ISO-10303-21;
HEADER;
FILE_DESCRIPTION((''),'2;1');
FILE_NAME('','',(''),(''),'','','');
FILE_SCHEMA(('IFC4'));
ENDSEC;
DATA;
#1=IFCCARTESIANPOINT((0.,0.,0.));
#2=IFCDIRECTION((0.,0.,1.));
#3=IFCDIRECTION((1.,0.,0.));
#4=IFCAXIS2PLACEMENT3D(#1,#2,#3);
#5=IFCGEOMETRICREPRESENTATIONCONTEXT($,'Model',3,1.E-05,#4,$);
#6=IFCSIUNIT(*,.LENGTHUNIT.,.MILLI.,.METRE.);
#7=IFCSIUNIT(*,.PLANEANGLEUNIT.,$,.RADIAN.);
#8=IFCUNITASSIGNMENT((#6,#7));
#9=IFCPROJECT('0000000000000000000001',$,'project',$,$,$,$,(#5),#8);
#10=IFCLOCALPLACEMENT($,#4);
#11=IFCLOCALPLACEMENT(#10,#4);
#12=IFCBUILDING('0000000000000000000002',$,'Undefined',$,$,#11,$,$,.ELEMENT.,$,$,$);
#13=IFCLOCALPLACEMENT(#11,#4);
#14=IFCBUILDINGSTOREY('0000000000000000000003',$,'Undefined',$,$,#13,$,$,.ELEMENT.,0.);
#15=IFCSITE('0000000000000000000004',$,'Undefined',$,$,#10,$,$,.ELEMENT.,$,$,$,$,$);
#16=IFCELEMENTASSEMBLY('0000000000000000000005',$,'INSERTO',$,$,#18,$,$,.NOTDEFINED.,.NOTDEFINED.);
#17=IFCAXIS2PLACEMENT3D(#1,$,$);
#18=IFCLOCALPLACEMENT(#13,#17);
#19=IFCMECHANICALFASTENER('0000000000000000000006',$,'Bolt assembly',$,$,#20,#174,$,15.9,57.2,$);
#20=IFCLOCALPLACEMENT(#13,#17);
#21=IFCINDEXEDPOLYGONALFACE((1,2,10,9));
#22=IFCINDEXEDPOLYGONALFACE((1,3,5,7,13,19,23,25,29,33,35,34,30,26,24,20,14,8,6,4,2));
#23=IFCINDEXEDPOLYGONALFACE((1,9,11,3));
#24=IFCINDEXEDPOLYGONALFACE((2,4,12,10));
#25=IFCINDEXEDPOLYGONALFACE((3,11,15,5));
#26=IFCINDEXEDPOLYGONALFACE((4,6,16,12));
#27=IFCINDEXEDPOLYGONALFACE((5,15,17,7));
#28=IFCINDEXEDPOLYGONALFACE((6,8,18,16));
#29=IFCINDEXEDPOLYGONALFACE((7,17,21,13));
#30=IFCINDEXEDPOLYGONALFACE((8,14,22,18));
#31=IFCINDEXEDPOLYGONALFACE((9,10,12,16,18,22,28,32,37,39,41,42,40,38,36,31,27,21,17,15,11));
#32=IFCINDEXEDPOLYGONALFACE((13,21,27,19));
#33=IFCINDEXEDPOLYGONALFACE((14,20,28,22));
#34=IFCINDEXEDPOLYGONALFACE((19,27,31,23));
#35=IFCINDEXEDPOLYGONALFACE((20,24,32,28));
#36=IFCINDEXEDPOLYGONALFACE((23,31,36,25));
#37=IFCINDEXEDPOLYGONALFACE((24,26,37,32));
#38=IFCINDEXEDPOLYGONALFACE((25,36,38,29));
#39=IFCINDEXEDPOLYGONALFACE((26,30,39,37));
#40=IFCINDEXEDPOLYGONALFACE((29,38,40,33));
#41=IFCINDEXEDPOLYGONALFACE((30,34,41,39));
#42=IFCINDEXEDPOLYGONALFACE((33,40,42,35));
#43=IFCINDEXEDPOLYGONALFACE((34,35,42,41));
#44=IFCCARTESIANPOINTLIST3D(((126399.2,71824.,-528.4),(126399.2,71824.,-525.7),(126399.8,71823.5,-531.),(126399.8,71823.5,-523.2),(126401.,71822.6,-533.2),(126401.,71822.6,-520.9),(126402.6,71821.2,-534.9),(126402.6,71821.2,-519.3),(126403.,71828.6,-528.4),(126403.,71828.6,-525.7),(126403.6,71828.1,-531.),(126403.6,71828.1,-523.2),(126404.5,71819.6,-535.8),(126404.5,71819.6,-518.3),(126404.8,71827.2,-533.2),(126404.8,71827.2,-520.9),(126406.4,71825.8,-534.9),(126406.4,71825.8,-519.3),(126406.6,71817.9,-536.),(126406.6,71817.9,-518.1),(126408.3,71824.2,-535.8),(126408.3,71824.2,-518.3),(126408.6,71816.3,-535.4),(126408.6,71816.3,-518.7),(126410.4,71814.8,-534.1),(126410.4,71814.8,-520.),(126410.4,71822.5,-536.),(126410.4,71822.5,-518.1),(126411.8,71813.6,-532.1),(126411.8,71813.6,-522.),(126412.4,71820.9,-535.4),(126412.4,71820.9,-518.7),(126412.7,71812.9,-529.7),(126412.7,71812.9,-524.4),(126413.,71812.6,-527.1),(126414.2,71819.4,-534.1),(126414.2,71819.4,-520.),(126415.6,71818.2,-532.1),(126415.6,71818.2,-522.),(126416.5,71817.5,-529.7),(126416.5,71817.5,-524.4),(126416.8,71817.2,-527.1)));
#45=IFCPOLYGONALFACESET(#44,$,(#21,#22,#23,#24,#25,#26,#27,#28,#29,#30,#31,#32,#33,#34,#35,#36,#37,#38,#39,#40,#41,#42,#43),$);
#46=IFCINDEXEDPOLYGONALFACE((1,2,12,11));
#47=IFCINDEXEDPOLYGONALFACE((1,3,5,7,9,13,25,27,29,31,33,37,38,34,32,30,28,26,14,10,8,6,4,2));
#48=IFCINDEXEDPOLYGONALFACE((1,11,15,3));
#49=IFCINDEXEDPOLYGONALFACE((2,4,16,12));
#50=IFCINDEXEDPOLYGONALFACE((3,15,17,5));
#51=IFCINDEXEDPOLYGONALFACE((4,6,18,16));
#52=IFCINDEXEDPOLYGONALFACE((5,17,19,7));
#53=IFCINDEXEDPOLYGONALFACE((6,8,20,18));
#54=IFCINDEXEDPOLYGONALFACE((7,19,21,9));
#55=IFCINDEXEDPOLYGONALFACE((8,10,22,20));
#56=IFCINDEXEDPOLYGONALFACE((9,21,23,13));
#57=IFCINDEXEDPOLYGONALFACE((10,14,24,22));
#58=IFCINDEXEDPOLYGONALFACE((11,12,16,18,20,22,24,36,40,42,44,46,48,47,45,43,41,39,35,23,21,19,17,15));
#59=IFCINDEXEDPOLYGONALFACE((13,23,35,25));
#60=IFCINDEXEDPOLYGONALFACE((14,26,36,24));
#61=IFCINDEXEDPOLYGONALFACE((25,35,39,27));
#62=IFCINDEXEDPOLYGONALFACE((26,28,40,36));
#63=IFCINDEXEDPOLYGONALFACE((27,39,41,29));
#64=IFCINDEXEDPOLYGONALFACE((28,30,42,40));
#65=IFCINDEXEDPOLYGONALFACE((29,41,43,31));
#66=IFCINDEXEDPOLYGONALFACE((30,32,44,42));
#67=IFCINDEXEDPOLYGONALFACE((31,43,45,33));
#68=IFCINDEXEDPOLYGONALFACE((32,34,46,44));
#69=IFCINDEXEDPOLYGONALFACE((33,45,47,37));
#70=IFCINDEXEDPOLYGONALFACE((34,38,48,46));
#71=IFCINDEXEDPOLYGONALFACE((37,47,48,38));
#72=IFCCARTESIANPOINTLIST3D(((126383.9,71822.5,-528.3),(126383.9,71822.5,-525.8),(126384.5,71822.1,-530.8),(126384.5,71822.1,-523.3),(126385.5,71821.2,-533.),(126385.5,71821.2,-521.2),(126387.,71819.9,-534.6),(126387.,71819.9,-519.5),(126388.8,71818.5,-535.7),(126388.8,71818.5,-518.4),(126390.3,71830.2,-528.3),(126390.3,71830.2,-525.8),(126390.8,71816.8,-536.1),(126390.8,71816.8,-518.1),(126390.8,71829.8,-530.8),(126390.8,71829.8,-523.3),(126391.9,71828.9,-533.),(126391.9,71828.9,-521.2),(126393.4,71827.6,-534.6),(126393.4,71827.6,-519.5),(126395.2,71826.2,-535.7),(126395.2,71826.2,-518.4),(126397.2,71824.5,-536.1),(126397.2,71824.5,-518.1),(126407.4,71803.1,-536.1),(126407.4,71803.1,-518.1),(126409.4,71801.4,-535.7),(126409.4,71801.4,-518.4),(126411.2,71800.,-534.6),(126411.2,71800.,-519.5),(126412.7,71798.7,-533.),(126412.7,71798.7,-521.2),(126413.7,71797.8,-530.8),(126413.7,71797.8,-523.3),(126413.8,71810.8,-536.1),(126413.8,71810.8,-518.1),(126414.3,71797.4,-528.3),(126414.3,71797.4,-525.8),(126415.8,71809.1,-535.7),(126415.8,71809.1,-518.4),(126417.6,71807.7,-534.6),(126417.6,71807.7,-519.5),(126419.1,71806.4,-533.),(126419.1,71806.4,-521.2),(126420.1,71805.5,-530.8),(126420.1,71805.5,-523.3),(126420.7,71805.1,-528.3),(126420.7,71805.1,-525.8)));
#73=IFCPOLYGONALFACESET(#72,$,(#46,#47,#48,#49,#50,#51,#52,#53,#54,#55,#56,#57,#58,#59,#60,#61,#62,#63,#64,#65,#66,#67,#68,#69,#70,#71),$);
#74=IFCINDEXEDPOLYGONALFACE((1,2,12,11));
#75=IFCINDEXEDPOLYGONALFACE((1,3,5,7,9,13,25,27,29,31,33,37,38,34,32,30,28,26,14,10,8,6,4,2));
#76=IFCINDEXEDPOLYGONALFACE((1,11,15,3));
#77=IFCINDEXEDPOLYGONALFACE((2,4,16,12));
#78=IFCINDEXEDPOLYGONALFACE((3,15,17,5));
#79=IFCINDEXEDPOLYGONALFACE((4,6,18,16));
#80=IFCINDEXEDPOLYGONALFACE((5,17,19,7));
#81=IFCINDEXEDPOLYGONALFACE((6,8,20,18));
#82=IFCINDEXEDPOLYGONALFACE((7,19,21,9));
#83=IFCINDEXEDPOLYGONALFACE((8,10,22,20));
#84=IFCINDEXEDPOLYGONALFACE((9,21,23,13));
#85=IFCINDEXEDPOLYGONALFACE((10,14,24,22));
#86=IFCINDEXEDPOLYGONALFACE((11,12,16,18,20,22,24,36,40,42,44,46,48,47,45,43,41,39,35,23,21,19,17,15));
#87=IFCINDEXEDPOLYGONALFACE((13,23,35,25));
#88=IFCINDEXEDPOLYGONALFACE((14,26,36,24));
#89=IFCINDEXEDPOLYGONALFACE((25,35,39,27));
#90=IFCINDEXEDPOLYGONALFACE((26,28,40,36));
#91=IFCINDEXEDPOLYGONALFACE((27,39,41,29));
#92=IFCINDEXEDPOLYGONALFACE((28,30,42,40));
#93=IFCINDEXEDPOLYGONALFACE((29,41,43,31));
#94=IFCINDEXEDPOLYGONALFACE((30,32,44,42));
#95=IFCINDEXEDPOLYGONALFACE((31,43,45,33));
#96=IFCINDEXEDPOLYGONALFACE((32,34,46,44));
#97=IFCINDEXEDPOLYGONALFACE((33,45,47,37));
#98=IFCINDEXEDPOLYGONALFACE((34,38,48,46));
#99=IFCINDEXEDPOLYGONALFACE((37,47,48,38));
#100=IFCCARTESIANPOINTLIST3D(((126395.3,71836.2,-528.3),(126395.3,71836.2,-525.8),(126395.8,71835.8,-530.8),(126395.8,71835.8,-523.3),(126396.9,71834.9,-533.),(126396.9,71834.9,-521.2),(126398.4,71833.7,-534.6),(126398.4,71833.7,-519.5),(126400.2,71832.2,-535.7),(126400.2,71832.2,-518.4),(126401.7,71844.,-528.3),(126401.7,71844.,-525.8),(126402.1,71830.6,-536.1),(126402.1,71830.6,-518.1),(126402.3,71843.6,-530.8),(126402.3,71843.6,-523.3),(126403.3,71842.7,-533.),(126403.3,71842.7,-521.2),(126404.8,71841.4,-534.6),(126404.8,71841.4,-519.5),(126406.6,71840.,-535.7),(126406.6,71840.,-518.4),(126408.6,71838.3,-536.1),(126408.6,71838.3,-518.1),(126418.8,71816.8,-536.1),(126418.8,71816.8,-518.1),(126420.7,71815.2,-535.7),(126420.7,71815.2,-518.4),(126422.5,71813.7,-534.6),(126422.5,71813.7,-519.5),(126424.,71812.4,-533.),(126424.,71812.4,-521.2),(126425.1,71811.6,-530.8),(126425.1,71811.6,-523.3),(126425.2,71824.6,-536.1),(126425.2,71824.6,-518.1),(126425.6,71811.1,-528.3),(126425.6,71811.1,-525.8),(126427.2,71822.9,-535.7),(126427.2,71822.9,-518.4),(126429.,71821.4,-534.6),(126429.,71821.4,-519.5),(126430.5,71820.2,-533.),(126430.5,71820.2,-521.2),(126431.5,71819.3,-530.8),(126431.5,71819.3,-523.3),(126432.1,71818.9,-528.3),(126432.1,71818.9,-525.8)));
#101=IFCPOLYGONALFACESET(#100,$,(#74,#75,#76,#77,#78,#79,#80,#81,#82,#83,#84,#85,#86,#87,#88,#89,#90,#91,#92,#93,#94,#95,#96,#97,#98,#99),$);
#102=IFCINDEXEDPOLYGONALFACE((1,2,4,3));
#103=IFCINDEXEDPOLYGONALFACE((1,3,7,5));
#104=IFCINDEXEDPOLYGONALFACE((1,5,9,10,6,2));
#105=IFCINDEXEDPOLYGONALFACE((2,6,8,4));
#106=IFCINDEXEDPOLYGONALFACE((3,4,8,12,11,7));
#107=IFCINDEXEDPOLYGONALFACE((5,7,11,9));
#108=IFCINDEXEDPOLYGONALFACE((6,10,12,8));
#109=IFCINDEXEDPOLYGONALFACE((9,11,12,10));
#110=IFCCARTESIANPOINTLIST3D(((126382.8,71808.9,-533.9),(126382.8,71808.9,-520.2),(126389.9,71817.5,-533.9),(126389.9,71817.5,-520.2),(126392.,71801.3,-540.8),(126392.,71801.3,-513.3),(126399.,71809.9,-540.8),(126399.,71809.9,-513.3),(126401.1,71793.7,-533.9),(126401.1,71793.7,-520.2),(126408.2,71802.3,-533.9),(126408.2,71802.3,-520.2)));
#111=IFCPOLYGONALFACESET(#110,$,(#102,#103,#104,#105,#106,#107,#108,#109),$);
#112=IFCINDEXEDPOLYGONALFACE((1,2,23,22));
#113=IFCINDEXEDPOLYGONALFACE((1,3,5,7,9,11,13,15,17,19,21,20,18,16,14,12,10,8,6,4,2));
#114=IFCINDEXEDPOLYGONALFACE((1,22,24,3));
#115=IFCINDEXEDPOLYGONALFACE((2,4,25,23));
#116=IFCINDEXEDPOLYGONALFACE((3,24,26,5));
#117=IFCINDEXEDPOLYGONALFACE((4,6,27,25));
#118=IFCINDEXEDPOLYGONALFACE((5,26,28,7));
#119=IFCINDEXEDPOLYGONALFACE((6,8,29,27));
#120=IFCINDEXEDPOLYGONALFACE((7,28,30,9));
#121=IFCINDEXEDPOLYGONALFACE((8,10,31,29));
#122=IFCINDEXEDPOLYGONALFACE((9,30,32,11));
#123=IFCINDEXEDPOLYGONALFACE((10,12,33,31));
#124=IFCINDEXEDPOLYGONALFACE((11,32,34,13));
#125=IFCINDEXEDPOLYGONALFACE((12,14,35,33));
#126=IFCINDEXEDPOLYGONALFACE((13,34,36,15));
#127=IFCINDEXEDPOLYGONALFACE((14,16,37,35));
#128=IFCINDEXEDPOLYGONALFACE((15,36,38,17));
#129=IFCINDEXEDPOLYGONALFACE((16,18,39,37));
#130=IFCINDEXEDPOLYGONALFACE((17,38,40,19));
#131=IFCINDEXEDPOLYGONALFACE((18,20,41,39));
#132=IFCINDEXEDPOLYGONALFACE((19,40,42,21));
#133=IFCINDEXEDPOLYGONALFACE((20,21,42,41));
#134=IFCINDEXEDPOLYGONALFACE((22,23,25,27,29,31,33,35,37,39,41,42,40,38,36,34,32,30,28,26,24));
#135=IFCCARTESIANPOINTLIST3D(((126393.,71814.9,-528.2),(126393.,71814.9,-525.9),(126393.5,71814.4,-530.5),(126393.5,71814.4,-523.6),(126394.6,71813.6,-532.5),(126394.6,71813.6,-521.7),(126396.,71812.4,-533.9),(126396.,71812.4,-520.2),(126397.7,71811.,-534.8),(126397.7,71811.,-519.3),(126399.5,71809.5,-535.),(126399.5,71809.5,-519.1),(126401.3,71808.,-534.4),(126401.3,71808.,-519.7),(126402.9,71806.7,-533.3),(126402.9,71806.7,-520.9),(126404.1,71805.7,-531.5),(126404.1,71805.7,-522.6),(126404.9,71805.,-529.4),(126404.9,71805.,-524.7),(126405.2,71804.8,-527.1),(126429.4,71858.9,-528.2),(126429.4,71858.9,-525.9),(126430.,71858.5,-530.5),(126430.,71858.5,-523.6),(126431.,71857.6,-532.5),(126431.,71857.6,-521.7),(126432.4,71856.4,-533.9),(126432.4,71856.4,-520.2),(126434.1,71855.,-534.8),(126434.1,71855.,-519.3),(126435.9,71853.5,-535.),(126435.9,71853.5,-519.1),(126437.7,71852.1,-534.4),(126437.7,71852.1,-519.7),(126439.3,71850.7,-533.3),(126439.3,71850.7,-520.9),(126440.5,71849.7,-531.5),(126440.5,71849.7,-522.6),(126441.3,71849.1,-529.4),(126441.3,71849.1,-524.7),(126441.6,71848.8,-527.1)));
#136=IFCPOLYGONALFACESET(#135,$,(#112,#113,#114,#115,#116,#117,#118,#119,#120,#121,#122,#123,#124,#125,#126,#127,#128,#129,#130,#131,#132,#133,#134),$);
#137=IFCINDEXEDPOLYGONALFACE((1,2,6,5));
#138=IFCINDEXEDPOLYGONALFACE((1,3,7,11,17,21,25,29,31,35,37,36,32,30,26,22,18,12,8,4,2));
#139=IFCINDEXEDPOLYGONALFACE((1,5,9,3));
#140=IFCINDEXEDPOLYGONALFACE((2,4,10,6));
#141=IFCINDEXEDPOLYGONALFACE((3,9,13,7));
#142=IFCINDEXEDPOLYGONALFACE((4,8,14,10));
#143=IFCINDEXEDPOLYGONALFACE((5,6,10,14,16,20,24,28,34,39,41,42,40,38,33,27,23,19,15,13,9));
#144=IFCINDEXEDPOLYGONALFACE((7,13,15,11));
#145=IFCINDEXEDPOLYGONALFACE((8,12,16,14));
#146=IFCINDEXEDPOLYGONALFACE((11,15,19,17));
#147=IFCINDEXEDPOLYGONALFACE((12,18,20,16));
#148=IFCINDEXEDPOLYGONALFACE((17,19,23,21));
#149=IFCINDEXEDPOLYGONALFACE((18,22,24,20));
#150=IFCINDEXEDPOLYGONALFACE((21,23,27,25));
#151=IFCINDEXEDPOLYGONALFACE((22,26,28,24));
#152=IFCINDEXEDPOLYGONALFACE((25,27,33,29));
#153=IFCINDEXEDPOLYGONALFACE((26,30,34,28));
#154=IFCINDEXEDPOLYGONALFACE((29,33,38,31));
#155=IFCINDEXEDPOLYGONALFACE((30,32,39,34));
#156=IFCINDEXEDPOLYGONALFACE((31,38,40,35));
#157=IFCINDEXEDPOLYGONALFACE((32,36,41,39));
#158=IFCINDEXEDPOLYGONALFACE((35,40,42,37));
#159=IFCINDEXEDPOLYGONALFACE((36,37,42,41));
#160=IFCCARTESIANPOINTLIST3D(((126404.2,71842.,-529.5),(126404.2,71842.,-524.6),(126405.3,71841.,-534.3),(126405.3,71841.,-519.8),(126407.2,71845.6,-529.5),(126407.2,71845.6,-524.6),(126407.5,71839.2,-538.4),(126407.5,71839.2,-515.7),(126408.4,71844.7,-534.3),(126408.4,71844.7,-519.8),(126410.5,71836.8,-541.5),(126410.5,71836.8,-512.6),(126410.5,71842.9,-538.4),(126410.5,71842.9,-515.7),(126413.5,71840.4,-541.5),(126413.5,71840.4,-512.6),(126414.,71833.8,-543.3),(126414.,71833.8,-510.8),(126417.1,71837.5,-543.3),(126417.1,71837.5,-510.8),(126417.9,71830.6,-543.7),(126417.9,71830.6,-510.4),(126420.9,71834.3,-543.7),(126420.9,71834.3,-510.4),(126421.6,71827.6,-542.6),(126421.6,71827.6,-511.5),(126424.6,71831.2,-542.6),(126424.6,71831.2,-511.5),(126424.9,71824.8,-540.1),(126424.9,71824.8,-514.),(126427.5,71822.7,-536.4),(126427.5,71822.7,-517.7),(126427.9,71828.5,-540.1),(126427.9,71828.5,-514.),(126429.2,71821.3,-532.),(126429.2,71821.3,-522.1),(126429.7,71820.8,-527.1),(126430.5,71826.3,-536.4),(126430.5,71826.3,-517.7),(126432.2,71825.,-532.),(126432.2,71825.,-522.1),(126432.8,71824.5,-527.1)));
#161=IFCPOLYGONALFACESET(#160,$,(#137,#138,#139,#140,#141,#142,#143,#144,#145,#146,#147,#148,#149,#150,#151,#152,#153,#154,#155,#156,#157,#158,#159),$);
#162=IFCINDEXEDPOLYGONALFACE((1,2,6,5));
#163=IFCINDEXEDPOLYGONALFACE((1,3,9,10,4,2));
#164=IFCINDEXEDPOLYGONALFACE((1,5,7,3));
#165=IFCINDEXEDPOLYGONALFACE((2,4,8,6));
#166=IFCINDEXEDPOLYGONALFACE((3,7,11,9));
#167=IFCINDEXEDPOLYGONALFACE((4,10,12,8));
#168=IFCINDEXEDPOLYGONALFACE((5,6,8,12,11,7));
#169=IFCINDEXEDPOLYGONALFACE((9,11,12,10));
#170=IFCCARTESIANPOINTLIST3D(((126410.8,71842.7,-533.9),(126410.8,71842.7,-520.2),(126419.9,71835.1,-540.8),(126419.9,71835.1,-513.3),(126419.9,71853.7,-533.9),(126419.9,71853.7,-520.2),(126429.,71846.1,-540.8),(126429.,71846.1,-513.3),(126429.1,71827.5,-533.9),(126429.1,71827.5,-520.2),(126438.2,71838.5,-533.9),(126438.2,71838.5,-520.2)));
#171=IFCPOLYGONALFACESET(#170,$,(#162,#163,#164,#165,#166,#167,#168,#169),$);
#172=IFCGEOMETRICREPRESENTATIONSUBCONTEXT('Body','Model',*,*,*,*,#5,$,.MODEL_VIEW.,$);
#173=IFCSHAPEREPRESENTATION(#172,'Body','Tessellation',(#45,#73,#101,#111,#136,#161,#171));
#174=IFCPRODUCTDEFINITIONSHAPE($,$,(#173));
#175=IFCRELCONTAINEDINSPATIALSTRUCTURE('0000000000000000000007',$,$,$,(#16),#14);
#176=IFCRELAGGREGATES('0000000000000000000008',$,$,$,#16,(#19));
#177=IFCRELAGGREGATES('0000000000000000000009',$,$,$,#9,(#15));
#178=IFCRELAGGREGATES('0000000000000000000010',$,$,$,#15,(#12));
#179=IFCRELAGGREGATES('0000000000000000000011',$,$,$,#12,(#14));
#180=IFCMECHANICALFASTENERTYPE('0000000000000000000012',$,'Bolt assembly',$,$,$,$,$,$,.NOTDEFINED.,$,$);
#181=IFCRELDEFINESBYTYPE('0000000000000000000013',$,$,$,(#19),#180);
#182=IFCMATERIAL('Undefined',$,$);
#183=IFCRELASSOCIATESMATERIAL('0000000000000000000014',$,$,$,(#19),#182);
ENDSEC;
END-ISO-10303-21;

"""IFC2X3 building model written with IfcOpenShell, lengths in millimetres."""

from ifc_helpers import new_model, entity, si_unit, frame, origin_with_axes, origin_2d_with_axis, place, context, subcontext, project, spatial, polyline, circle, outline, extrude, source, transform, mapped, material, type_object, element, aggregate, save


model = new_model("IFC2X3")

# Units and contexts
model_context = context("Model", 3, precision=1e-05, world=origin_with_axes())
body_context = subcontext(model_context, "Body", "Model", "MODEL_VIEW")
ifc_project = project(units=[si_unit("LENGTHUNIT", "METRE", prefix="MILLI"), si_unit("PLANEANGLEUNIT", "RADIAN")], contexts=[model_context])

# Site, building, storey
site_placement = place(None, origin_with_axes())
site = spatial("IfcSite", under=ifc_project, at=site_placement, Name="Undefined", CompositionType="ELEMENT")
building_placement = place(site_placement, origin_with_axes())
building = spatial("IfcBuilding", under=site, at=building_placement, Name="Undefined", CompositionType="ELEMENT")
storey_placement = place(building_placement, origin_with_axes())
storey = spatial("IfcBuildingStorey", under=building, at=storey_placement, Name="Undefined", CompositionType="ELEMENT", Elevation=0.0)

# Element assembly
assembly_1_placement = place(storey_placement, origin_with_axes())
assembly_1 = element("IfcElementAssembly", 1, at=assembly_1_placement, inside=storey, Name="INSERTO", AssemblyPlace="NOTDEFINED", PredefinedType="NOTDEFINED")

# Mechanical fastener
ifc_material_1 = material(Name="Undefined")
mechanical_fastener_type = type_object("IfcMechanicalFastenerType", Name="Bolt assembly")
shared_circle_1 = entity("IfcCircle", entity("IfcAxis2Placement2D", entity("IfcCartesianPoint", [10.8, 0.0]), entity("IfcDirection", [0.0, 1.0])), 9.0)
shared_circle_2 = entity("IfcCircle", entity("IfcAxis2Placement2D", entity("IfcCartesianPoint", [-10.8, 0.0]), entity("IfcDirection", [0.0, -1.0])), 9.0)
shared_composite_curve = entity("IfcCompositeCurve", [entity("IfcCompositeCurveSegment", "CONTINUOUS", True, entity("IfcPolyline", [entity("IfcCartesianPoint", [-10.8, 9.0]), entity("IfcCartesianPoint", [10.8, 9.0])])), entity("IfcCompositeCurveSegment", "CONTINUOUS", True, entity("IfcTrimmedCurve", shared_circle_1, [entity("IfcParameterValue", 0.0)], [entity("IfcParameterValue", 3.141593)], False, "PARAMETER")), entity("IfcCompositeCurveSegment", "CONTINUOUS", True, entity("IfcPolyline", [entity("IfcCartesianPoint", [10.8, -9.0]), entity("IfcCartesianPoint", [-10.8, -9.0])])), entity("IfcCompositeCurveSegment", "DISCONTINUOUS", True, entity("IfcTrimmedCurve", shared_circle_2, [entity("IfcParameterValue", 0.0)], [entity("IfcParameterValue", 3.141593)], False, "PARAMETER"))], False)
shared_shape_1 = source(origin_with_axes(), body_context, "Body", "SweptSolid", [
    extrude(circle(Radius=9.0, at=origin_2d_with_axis()), frame((0.0, 6.0, 0.0), z_axis=(0.0, 1.0, 0.0), x_axis=(1.0, 0.0, 0.0)), (0.0, 0.0, 1.0), 6.0),
    entity("IfcExtrudedAreaSolid", entity("IfcArbitraryClosedProfileDef", "AREA", None, shared_composite_curve), entity("IfcAxis2Placement3D", entity("IfcCartesianPoint", [0.0, -4.9, 0.0]), entity("IfcDirection", [0.0, 1.0, 0.0]), entity("IfcDirection", [1.0, 0.0, 0.0])), entity("IfcDirection", [0.0, 0.0, 1.0]), 10.0),
    entity("IfcExtrudedAreaSolid", entity("IfcArbitraryClosedProfileDef", "AREA", None, shared_composite_curve), entity("IfcAxis2Placement3D", entity("IfcCartesianPoint", [0.0, 12.9, 0.0]), entity("IfcDirection", [0.0, 1.0, 0.0]), entity("IfcDirection", [1.0, 0.0, 0.0])), entity("IfcDirection", [0.0, 0.0, 1.0]), 10.1),
    extrude(outline(polyline([(11.9, -6.9), (11.9, 6.9), (0.0, 13.7), (-11.9, 6.9), (-11.9, -6.9), (0.0, -13.7), (11.9, -6.9)])), frame((0.0, -16.1, 0.0), z_axis=(0.0, 1.0, 0.0), x_axis=(1.0, 0.0, 0.0)), (0.0, 0.0, 1.0), 11.1),
    extrude(circle(Radius=7.9, at=origin_2d_with_axis()), frame((0.0, -5.0, 0.0), z_axis=(0.0, 1.0, 0.0), x_axis=(1.0, 0.0, 0.0)), (0.0, 0.0, 1.0), 57.1),
    extrude(circle(Radius=16.7, at=origin_2d_with_axis()), frame((0.0, 23.0, 0.0), z_axis=(0.0, 1.0, 0.0), x_axis=(1.0, 0.0, 0.0)), (0.0, 0.0, 1.0), 4.8),
    extrude(outline(polyline([(11.9, -6.9), (11.9, 6.9), (0.0, 13.7), (-11.9, 6.9), (-11.9, -6.9), (0.0, -13.7), (11.9, -6.9)])), frame((0.0, 27.8, 0.0), z_axis=(0.0, 1.0, 0.0), x_axis=(1.0, 0.0, 0.0)), (0.0, 0.0, 1.0), 14.3),
])
mechanical_fastener_1_placement = place(assembly_1_placement, frame((126402.2, 71813.7, -527.1), z_axis=(0.0, 0.0, 1.0), x_axis=(0.7704, -0.63756, 0.0)))
mechanical_fastener_1 = element("IfcMechanicalFastener", 2, at=mechanical_fastener_1_placement, type_object=mechanical_fastener_type, material=ifc_material_1, Name="Bolt assembly", NominalDiameter=15.9, NominalLength=57.2, context=body_context, shape_type="MappedRepresentation", body=[
    mapped(shared_shape_1, transform((0.0, 0.0, 0.0))),
])
aggregate(assembly_1, [mechanical_fastener_1])

save(model, "model.ifc")
